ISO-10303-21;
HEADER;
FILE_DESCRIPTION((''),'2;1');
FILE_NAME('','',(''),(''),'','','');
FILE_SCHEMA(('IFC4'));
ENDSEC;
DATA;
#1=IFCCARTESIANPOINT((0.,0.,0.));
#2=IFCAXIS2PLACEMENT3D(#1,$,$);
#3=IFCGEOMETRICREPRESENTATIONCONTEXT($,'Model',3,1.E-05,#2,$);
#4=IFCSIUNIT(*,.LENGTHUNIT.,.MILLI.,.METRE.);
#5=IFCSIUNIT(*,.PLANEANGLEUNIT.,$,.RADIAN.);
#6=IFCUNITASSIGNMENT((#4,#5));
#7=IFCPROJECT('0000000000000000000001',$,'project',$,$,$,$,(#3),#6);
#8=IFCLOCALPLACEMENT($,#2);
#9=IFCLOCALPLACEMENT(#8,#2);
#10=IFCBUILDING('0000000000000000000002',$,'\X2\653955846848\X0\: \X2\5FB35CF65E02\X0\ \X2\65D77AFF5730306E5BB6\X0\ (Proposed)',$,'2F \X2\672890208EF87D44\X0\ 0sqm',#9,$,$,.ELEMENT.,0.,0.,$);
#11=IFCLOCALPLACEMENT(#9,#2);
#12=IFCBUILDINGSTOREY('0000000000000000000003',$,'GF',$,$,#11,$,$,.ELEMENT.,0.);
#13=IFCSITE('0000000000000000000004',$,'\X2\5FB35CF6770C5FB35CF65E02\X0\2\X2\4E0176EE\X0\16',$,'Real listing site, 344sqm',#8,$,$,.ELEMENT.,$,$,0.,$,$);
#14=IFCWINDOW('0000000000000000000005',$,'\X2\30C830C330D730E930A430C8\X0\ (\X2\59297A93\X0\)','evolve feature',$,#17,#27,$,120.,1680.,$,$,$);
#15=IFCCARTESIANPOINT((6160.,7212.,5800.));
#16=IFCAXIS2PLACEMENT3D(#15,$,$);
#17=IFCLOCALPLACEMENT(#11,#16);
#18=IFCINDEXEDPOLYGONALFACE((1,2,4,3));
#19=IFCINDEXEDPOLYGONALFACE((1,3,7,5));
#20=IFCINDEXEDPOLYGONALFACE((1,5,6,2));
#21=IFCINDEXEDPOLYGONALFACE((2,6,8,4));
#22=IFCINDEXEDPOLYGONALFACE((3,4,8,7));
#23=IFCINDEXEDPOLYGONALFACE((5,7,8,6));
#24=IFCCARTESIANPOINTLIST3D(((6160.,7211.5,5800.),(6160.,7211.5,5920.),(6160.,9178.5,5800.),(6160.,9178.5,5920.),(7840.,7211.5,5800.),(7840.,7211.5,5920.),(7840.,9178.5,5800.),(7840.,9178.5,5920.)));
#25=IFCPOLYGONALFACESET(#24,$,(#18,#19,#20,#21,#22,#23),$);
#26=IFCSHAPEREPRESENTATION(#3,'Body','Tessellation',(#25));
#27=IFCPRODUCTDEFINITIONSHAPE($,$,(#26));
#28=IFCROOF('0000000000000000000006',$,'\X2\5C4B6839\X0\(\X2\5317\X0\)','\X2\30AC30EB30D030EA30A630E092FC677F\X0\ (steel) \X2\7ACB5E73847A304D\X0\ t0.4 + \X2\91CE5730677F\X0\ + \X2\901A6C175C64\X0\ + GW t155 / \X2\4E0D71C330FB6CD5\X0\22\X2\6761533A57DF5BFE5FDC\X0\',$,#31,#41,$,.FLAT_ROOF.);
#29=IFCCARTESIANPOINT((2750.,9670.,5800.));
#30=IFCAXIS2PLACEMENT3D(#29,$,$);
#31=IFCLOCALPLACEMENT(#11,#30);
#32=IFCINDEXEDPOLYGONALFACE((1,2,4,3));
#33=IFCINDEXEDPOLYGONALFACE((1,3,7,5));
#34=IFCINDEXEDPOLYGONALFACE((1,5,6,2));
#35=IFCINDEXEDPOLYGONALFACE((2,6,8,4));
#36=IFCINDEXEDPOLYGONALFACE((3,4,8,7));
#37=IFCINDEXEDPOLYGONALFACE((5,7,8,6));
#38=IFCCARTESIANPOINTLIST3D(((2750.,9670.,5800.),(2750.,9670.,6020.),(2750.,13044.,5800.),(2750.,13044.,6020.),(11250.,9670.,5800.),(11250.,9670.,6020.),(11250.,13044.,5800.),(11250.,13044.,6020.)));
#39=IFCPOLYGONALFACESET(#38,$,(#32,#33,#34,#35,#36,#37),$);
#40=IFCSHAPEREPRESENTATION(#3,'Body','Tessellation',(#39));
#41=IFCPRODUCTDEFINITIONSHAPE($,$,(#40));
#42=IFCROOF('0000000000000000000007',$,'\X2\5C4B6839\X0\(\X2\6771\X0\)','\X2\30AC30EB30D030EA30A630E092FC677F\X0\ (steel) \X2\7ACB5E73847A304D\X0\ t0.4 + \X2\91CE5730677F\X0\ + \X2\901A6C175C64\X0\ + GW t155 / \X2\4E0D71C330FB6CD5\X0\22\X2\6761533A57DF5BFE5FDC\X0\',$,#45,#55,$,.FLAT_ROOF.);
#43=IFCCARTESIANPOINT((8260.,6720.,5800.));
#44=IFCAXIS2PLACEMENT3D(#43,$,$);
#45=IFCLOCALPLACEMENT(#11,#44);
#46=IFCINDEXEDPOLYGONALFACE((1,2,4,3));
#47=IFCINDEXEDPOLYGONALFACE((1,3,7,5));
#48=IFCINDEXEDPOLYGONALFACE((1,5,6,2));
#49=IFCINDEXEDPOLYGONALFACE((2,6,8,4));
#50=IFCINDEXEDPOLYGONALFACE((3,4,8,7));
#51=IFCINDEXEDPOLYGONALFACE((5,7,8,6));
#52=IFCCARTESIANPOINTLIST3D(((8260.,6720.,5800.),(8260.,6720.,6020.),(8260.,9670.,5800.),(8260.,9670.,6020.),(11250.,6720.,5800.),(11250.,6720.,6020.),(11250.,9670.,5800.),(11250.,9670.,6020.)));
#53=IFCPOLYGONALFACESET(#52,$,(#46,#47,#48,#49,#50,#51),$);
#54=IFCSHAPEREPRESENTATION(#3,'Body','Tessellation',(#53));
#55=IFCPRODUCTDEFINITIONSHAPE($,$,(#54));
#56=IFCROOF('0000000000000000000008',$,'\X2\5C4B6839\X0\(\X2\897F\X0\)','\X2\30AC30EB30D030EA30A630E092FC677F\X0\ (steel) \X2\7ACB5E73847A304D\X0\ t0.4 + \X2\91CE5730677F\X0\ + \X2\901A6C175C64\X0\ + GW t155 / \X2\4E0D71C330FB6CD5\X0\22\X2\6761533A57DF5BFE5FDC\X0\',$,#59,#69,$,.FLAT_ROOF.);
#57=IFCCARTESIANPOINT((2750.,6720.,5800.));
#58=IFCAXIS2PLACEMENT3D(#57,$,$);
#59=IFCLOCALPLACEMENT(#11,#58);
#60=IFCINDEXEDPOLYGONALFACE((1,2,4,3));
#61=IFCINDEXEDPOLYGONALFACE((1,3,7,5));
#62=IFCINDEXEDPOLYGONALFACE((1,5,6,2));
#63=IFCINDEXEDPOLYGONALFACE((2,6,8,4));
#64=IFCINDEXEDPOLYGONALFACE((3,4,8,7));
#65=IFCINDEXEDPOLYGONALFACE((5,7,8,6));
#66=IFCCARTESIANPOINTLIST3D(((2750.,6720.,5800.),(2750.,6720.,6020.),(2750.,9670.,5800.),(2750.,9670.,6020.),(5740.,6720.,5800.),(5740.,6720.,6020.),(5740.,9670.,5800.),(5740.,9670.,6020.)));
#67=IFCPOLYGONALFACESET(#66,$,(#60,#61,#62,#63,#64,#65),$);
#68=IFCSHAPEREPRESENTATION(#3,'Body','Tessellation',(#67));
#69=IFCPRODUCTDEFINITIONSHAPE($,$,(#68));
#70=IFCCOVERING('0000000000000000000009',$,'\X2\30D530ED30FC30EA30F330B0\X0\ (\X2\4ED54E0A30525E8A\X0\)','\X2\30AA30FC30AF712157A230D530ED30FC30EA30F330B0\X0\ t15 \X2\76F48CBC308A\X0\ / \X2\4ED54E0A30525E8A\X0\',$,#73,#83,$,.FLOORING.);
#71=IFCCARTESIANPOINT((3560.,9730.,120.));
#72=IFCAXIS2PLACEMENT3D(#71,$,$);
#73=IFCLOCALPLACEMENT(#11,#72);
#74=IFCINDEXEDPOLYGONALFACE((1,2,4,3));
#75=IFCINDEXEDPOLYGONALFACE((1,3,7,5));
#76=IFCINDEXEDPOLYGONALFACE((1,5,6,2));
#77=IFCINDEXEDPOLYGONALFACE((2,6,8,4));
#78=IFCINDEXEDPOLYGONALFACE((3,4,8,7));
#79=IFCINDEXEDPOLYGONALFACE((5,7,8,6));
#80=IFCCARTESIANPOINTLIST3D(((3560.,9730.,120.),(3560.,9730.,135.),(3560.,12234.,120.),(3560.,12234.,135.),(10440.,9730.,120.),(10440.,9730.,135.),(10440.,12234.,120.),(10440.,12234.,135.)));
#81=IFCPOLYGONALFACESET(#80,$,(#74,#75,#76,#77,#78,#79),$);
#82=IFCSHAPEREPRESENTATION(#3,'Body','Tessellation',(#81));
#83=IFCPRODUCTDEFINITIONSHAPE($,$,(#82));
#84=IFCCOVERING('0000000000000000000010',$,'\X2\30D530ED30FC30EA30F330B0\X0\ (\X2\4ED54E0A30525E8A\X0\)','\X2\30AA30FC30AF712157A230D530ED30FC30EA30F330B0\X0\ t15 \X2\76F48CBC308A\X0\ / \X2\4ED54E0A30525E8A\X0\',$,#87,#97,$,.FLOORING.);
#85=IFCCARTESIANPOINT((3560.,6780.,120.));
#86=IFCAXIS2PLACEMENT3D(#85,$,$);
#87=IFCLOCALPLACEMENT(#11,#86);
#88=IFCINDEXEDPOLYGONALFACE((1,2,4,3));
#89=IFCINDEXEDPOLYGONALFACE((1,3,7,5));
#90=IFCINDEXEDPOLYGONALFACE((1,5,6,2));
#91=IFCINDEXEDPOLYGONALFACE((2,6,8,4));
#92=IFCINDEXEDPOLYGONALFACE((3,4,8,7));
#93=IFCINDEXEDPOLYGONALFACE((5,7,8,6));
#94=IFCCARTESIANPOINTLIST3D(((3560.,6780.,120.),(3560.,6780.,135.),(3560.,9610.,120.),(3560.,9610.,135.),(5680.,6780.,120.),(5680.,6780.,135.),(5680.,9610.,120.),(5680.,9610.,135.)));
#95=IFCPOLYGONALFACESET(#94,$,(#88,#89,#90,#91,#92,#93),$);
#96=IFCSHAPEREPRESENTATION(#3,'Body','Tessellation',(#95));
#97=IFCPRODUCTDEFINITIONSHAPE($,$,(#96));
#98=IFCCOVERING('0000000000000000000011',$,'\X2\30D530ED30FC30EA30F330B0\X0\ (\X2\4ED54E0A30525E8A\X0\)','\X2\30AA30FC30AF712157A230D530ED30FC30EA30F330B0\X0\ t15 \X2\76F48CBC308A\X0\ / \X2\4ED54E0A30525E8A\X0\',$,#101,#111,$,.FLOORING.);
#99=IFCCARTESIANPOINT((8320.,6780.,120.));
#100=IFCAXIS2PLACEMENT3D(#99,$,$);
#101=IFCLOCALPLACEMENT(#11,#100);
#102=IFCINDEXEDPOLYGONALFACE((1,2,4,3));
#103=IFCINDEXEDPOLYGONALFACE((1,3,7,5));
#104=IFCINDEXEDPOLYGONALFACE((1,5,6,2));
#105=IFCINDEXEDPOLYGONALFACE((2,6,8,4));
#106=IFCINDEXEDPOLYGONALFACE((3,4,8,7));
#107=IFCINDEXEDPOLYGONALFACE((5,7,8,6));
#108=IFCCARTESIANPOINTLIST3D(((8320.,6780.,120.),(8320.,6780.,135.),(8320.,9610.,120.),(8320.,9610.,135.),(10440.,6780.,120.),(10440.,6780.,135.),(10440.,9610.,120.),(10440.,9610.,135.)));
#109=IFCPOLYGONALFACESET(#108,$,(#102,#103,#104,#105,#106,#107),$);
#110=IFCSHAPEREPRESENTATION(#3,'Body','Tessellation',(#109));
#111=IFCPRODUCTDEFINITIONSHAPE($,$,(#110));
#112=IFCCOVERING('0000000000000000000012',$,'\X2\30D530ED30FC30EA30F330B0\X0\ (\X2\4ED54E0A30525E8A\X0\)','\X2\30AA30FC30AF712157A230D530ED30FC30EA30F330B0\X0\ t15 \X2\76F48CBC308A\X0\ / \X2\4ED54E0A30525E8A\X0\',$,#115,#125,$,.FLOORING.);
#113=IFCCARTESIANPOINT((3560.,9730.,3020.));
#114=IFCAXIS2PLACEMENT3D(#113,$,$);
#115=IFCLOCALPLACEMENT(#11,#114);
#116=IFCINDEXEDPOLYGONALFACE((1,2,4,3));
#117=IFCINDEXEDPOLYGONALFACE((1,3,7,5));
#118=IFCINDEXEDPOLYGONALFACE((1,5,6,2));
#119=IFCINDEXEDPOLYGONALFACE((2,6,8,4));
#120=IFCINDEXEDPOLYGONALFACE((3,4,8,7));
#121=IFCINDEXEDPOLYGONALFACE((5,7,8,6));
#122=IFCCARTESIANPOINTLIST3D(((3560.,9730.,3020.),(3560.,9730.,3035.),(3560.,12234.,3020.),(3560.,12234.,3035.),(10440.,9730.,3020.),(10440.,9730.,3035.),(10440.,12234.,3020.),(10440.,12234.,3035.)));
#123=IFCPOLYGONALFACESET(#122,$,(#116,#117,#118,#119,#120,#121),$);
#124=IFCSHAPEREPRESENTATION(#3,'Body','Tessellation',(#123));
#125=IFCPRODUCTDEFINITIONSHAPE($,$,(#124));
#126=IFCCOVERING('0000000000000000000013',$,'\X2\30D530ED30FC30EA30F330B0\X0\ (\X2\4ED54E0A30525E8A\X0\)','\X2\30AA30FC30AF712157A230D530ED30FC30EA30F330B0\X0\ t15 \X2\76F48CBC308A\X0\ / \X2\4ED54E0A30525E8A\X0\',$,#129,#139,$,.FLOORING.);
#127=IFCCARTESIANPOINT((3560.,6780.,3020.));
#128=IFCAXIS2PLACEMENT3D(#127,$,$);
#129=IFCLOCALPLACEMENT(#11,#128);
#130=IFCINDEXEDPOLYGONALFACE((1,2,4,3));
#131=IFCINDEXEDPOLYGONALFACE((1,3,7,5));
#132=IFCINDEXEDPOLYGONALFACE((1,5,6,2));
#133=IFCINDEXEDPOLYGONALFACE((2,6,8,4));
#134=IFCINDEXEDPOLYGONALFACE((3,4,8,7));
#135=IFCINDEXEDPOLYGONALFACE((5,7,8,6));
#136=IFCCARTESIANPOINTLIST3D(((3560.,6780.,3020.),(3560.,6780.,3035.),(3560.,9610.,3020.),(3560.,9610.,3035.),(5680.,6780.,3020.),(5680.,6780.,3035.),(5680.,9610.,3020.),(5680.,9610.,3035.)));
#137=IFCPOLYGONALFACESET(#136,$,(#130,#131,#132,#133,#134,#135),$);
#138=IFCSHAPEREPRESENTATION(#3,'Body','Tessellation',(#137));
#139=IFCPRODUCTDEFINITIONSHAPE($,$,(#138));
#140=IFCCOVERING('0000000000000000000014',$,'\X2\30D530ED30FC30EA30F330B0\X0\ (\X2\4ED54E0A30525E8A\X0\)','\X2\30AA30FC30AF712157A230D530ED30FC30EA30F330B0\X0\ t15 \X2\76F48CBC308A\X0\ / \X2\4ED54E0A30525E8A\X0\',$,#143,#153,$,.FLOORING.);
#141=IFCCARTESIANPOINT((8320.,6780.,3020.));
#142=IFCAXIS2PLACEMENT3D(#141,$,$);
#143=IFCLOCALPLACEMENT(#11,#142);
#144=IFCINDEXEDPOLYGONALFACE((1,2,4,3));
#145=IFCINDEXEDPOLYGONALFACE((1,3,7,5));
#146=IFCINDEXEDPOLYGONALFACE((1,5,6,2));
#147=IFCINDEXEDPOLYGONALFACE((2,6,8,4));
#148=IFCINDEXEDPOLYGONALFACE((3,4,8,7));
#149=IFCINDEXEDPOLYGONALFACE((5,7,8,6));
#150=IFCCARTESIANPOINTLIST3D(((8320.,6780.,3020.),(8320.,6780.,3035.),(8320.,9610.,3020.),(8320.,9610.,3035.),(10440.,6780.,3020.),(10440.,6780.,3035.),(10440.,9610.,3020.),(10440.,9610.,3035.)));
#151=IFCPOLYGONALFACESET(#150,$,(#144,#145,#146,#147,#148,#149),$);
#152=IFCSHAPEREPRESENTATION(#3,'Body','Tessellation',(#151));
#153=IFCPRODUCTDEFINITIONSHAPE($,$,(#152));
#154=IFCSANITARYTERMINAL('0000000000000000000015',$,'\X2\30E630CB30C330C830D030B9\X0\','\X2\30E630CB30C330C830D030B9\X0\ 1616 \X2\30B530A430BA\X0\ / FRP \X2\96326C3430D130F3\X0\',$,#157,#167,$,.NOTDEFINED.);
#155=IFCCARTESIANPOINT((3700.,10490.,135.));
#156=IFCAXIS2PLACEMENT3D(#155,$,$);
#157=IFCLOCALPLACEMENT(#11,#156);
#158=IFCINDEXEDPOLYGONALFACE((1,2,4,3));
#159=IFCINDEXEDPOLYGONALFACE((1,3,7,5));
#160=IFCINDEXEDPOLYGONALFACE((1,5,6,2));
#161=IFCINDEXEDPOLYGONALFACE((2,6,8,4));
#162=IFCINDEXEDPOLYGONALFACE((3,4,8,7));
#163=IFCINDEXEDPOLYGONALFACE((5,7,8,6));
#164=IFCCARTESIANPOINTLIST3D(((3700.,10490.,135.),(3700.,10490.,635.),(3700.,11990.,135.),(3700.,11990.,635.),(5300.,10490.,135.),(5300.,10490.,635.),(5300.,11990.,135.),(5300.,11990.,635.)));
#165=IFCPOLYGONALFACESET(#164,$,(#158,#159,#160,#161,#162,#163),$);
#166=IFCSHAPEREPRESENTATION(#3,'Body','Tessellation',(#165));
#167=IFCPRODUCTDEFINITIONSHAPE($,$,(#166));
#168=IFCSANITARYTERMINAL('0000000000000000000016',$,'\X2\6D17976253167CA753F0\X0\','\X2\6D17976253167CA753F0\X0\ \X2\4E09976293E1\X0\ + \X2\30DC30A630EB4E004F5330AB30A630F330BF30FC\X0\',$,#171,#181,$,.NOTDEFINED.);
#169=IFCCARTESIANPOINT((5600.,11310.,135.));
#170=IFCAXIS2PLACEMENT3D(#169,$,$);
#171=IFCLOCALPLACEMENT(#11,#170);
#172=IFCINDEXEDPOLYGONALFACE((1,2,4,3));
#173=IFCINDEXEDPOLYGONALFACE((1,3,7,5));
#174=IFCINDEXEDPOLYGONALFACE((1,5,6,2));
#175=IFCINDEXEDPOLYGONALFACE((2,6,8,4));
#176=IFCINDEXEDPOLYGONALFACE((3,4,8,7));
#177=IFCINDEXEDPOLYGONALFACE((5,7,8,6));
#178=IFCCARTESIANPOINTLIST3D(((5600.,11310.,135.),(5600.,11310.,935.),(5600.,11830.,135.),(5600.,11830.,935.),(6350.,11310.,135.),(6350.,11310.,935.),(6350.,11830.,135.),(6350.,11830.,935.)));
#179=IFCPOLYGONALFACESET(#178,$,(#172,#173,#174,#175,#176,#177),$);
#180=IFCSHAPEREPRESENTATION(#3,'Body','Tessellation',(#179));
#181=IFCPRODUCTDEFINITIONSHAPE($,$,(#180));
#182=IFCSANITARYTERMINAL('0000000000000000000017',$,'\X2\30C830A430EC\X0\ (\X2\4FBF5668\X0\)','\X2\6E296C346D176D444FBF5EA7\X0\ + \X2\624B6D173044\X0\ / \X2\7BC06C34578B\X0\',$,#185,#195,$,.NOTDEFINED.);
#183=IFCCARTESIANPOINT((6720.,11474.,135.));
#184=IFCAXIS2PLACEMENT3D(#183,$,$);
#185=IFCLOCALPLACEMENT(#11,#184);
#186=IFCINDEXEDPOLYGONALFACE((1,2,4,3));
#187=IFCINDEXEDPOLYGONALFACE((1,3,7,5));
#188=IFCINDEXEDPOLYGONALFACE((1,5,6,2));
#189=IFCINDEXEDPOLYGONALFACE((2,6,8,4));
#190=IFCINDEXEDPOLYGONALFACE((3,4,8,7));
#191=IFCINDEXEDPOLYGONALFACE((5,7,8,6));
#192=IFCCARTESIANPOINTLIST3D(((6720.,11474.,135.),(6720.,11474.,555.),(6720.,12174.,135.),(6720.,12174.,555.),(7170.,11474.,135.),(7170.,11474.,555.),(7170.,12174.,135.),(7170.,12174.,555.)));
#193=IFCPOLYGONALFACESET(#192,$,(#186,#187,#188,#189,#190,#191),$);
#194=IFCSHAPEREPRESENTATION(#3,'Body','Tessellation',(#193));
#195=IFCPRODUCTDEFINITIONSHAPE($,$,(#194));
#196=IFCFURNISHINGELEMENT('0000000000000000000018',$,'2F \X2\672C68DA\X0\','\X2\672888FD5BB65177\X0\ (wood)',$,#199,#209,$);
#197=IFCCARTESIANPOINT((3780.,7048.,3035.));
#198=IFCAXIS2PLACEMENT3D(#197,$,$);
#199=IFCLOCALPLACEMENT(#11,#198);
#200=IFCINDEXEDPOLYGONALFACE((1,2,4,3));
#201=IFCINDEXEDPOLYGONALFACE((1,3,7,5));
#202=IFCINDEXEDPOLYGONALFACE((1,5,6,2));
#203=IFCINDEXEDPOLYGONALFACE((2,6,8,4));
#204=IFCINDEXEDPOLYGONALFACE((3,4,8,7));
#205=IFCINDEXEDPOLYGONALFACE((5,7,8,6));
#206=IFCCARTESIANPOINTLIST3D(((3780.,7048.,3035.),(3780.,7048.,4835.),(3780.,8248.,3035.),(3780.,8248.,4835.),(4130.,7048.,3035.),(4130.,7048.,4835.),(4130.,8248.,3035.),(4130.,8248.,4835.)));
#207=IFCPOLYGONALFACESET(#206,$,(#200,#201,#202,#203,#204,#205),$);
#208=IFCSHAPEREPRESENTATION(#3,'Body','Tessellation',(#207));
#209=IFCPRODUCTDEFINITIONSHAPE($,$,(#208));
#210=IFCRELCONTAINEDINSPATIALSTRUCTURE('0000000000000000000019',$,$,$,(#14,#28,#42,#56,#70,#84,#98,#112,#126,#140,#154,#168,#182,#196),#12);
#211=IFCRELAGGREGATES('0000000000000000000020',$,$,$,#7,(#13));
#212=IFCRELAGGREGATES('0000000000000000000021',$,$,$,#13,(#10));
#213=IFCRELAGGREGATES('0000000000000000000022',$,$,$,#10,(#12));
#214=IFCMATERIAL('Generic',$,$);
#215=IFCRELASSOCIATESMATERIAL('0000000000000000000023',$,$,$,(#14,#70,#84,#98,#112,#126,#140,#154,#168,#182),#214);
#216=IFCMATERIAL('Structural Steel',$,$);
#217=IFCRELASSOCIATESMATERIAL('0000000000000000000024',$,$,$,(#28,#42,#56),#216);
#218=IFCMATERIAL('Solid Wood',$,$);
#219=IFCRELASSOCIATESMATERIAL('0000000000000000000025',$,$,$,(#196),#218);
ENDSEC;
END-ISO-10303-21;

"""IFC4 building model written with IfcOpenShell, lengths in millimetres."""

from ifc_helpers import new_model, si_unit, frame, frame_2d, origin, place, context, project, spatial, rectangle, extrude, material, element, save


model = new_model("IFC4")

# Units and contexts
model_context = context("Model", 3, precision=1e-05, world=origin())
ifc_project = project(units=[si_unit("LENGTHUNIT", "METRE", prefix="MILLI"), si_unit("PLANEANGLEUNIT", "RADIAN")], contexts=[model_context])

# Site, building, storey
site_placement = place(None, origin())
site = spatial("IfcSite", under=ifc_project, at=site_placement, Name="徳島県徳島市2丁目16", ObjectType="Real listing site, 344sqm", CompositionType="ELEMENT", RefElevation=0.0)
building_placement = place(site_placement, origin())
building = spatial("IfcBuilding", under=site, at=building_placement, Name="改善案: 徳島市 旗竿地の家 (Proposed)", ObjectType="2F 木造軸組 0sqm", CompositionType="ELEMENT", ElevationOfRefHeight=0.0, ElevationOfTerrain=0.0)
storey_placement = place(building_placement, origin())
storey = spatial("IfcBuildingStorey", under=building, at=storey_placement, Name="GF", CompositionType="ELEMENT", Elevation=0.0)

# Shared definitions
ifc_material_1 = material(Name="Solid Wood")

# Window
ifc_material_2 = material(Name="Generic")
window_1_placement = place(storey_placement, frame((6160.0, 7212.0, 5800.0)))
element("IfcWindow", 1, at=window_1_placement, inside=storey, material=ifc_material_2, Name="トップライト (天窓)", Description="evolve feature", OverallHeight=120.0, OverallWidth=1680.0, context=model_context, shape_type="SweptSolid", body=[
    extrude(rectangle(XDim=1680.0, YDim=1967.0, at=frame_2d((840.0, 983.0))), frame((6160.0, 7212.0, 5800.0)), (0.0, 0.0, 1.0), 120.0),
])

# Roofs
ifc_material_3 = material(Name="Structural Steel")
roof_1_placement = place(storey_placement, frame((2750.0, 9670.0, 5800.0)))
element("IfcRoof", 2, at=roof_1_placement, inside=storey, material=ifc_material_3, Name="屋根(北)", Description="ガルバリウム鋼板 (steel) 立平葺き t0.4 + 野地板 + 通気層 + GW t155 / 不燃・法22条区域対応", PredefinedType="FLAT_ROOF", context=model_context, shape_type="SweptSolid", body=[
    extrude(rectangle(XDim=8500.0, YDim=3374.0, at=frame_2d((4250.0, 1687.0))), frame((2750.0, 9670.0, 5800.0)), (0.0, 0.0, 1.0), 220.0),
])
roof_2_placement = place(storey_placement, frame((8260.0, 6720.0, 5800.0)))
element("IfcRoof", 3, at=roof_2_placement, inside=storey, material=ifc_material_3, Name="屋根(東)", Description="ガルバリウム鋼板 (steel) 立平葺き t0.4 + 野地板 + 通気層 + GW t155 / 不燃・法22条区域対応", PredefinedType="FLAT_ROOF", context=model_context, shape_type="SweptSolid", body=[
    extrude(rectangle(XDim=2990.0, YDim=2950.0, at=frame_2d((1495.0, 1475.0))), frame((8260.0, 6720.0, 5800.0)), (0.0, 0.0, 1.0), 220.0),
])
roof_3_placement = place(storey_placement, frame((2750.0, 6720.0, 5800.0)))
element("IfcRoof", 4, at=roof_3_placement, inside=storey, material=ifc_material_3, Name="屋根(西)", Description="ガルバリウム鋼板 (steel) 立平葺き t0.4 + 野地板 + 通気層 + GW t155 / 不燃・法22条区域対応", PredefinedType="FLAT_ROOF", context=model_context, shape_type="SweptSolid", body=[
    extrude(rectangle(XDim=2990.0, YDim=2950.0, at=frame_2d((1495.0, 1475.0))), frame((2750.0, 6720.0, 5800.0)), (0.0, 0.0, 1.0), 220.0),
])

# Coverings
covering_1_placement = place(storey_placement, frame((3560.0, 9730.0, 120.0)))
element("IfcCovering", 5, at=covering_1_placement, inside=storey, material=ifc_material_2, Name="フローリング (仕上げ床)", Description="オーク無垢フローリング t15 直貼り / 仕上げ床", PredefinedType="FLOORING", context=model_context, shape_type="SweptSolid", body=[
    extrude(rectangle(XDim=6880.0, YDim=2504.0, at=frame_2d((3440.0, 1252.0))), frame((3560.0, 9730.0, 120.0)), (0.0, 0.0, 1.0), 15.0),
])
covering_2_placement = place(storey_placement, frame((3560.0, 6780.0, 120.0)))
element("IfcCovering", 6, at=covering_2_placement, inside=storey, material=ifc_material_2, Name="フローリング (仕上げ床)", Description="オーク無垢フローリング t15 直貼り / 仕上げ床", PredefinedType="FLOORING", context=model_context, shape_type="SweptSolid", body=[
    extrude(rectangle(XDim=2120.0, YDim=2830.0, at=frame_2d((1060.0, 1415.0))), frame((3560.0, 6780.0, 120.0)), (0.0, 0.0, 1.0), 15.0),
])
covering_3_placement = place(storey_placement, frame((8320.0, 6780.0, 120.0)))
element("IfcCovering", 7, at=covering_3_placement, inside=storey, material=ifc_material_2, Name="フローリング (仕上げ床)", Description="オーク無垢フローリング t15 直貼り / 仕上げ床", PredefinedType="FLOORING", context=model_context, shape_type="SweptSolid", body=[
    extrude(rectangle(XDim=2120.0, YDim=2830.0, at=frame_2d((1060.0, 1415.0))), frame((8320.0, 6780.0, 120.0)), (0.0, 0.0, 1.0), 15.0),
])
covering_4_placement = place(storey_placement, frame((3560.0, 9730.0, 3020.0)))
element("IfcCovering", 8, at=covering_4_placement, inside=storey, material=ifc_material_2, Name="フローリング (仕上げ床)", Description="オーク無垢フローリング t15 直貼り / 仕上げ床", PredefinedType="FLOORING", context=model_context, shape_type="SweptSolid", body=[
    extrude(rectangle(XDim=6880.0, YDim=2504.0, at=frame_2d((3440.0, 1252.0))), frame((3560.0, 9730.0, 3020.0)), (0.0, 0.0, 1.0), 15.0),
])
covering_5_placement = place(storey_placement, frame((3560.0, 6780.0, 3020.0)))
element("IfcCovering", 9, at=covering_5_placement, inside=storey, material=ifc_material_2, Name="フローリング (仕上げ床)", Description="オーク無垢フローリング t15 直貼り / 仕上げ床", PredefinedType="FLOORING", context=model_context, shape_type="SweptSolid", body=[
    extrude(rectangle(XDim=2120.0, YDim=2830.0, at=frame_2d((1060.0, 1415.0))), frame((3560.0, 6780.0, 3020.0)), (0.0, 0.0, 1.0), 15.0),
])
covering_6_placement = place(storey_placement, frame((8320.0, 6780.0, 3020.0)))
element("IfcCovering", 10, at=covering_6_placement, inside=storey, material=ifc_material_2, Name="フローリング (仕上げ床)", Description="オーク無垢フローリング t15 直貼り / 仕上げ床", PredefinedType="FLOORING", context=model_context, shape_type="SweptSolid", body=[
    extrude(rectangle(XDim=2120.0, YDim=2830.0, at=frame_2d((1060.0, 1415.0))), frame((8320.0, 6780.0, 3020.0)), (0.0, 0.0, 1.0), 15.0),
])

# Sanitary terminals
sanitary_terminal_1_placement = place(storey_placement, frame((3700.0, 10490.0, 135.0)))
element("IfcSanitaryTerminal", 11, at=sanitary_terminal_1_placement, inside=storey, material=ifc_material_2, Name="ユニットバス", Description="ユニットバス 1616 サイズ / FRP 防水パン", PredefinedType="NOTDEFINED", context=model_context, shape_type="SweptSolid", body=[
    extrude(rectangle(XDim=1600.0, YDim=1500.0, at=frame_2d((800.0, 750.0))), frame((3700.0, 10490.0, 135.0)), (0.0, 0.0, 1.0), 500.0),
])
sanitary_terminal_2_placement = place(storey_placement, frame((5600.0, 11310.0, 135.0)))
element("IfcSanitaryTerminal", 12, at=sanitary_terminal_2_placement, inside=storey, material=ifc_material_2, Name="洗面化粧台", Description="洗面化粧台 三面鏡 + ボウル一体カウンター", PredefinedType="NOTDEFINED", context=model_context, shape_type="SweptSolid", body=[
    extrude(rectangle(XDim=750.0, YDim=520.0, at=frame_2d((375.0, 260.0))), frame((5600.0, 11310.0, 135.0)), (0.0, 0.0, 1.0), 800.0),
])
sanitary_terminal_3_placement = place(storey_placement, frame((6720.0, 11474.0, 135.0)))
element("IfcSanitaryTerminal", 13, at=sanitary_terminal_3_placement, inside=storey, material=ifc_material_2, Name="トイレ (便器)", Description="温水洗浄便座 + 手洗い / 節水型", PredefinedType="NOTDEFINED", context=model_context, shape_type="SweptSolid", body=[
    extrude(rectangle(XDim=450.0, YDim=700.0, at=frame_2d((225.0, 350.0))), frame((6720.0, 11474.0, 135.0)), (0.0, 0.0, 1.0), 420.0),
])

# Furnishing element
furnishing_placement = place(storey_placement, frame((3780.0, 7048.0, 3035.0)))
element("IfcFurnishingElement", 14, at=furnishing_placement, inside=storey, material=ifc_material_1, Name="2F 本棚", Description="木製家具 (wood)", context=model_context, shape_type="SweptSolid", body=[
    extrude(rectangle(XDim=350.0, YDim=1200.0, at=frame_2d((175.0, 600.0))), frame((3780.0, 7048.0, 3035.0)), (0.0, 0.0, 1.0), 1800.0),
])

save(model, "model.ifc")
